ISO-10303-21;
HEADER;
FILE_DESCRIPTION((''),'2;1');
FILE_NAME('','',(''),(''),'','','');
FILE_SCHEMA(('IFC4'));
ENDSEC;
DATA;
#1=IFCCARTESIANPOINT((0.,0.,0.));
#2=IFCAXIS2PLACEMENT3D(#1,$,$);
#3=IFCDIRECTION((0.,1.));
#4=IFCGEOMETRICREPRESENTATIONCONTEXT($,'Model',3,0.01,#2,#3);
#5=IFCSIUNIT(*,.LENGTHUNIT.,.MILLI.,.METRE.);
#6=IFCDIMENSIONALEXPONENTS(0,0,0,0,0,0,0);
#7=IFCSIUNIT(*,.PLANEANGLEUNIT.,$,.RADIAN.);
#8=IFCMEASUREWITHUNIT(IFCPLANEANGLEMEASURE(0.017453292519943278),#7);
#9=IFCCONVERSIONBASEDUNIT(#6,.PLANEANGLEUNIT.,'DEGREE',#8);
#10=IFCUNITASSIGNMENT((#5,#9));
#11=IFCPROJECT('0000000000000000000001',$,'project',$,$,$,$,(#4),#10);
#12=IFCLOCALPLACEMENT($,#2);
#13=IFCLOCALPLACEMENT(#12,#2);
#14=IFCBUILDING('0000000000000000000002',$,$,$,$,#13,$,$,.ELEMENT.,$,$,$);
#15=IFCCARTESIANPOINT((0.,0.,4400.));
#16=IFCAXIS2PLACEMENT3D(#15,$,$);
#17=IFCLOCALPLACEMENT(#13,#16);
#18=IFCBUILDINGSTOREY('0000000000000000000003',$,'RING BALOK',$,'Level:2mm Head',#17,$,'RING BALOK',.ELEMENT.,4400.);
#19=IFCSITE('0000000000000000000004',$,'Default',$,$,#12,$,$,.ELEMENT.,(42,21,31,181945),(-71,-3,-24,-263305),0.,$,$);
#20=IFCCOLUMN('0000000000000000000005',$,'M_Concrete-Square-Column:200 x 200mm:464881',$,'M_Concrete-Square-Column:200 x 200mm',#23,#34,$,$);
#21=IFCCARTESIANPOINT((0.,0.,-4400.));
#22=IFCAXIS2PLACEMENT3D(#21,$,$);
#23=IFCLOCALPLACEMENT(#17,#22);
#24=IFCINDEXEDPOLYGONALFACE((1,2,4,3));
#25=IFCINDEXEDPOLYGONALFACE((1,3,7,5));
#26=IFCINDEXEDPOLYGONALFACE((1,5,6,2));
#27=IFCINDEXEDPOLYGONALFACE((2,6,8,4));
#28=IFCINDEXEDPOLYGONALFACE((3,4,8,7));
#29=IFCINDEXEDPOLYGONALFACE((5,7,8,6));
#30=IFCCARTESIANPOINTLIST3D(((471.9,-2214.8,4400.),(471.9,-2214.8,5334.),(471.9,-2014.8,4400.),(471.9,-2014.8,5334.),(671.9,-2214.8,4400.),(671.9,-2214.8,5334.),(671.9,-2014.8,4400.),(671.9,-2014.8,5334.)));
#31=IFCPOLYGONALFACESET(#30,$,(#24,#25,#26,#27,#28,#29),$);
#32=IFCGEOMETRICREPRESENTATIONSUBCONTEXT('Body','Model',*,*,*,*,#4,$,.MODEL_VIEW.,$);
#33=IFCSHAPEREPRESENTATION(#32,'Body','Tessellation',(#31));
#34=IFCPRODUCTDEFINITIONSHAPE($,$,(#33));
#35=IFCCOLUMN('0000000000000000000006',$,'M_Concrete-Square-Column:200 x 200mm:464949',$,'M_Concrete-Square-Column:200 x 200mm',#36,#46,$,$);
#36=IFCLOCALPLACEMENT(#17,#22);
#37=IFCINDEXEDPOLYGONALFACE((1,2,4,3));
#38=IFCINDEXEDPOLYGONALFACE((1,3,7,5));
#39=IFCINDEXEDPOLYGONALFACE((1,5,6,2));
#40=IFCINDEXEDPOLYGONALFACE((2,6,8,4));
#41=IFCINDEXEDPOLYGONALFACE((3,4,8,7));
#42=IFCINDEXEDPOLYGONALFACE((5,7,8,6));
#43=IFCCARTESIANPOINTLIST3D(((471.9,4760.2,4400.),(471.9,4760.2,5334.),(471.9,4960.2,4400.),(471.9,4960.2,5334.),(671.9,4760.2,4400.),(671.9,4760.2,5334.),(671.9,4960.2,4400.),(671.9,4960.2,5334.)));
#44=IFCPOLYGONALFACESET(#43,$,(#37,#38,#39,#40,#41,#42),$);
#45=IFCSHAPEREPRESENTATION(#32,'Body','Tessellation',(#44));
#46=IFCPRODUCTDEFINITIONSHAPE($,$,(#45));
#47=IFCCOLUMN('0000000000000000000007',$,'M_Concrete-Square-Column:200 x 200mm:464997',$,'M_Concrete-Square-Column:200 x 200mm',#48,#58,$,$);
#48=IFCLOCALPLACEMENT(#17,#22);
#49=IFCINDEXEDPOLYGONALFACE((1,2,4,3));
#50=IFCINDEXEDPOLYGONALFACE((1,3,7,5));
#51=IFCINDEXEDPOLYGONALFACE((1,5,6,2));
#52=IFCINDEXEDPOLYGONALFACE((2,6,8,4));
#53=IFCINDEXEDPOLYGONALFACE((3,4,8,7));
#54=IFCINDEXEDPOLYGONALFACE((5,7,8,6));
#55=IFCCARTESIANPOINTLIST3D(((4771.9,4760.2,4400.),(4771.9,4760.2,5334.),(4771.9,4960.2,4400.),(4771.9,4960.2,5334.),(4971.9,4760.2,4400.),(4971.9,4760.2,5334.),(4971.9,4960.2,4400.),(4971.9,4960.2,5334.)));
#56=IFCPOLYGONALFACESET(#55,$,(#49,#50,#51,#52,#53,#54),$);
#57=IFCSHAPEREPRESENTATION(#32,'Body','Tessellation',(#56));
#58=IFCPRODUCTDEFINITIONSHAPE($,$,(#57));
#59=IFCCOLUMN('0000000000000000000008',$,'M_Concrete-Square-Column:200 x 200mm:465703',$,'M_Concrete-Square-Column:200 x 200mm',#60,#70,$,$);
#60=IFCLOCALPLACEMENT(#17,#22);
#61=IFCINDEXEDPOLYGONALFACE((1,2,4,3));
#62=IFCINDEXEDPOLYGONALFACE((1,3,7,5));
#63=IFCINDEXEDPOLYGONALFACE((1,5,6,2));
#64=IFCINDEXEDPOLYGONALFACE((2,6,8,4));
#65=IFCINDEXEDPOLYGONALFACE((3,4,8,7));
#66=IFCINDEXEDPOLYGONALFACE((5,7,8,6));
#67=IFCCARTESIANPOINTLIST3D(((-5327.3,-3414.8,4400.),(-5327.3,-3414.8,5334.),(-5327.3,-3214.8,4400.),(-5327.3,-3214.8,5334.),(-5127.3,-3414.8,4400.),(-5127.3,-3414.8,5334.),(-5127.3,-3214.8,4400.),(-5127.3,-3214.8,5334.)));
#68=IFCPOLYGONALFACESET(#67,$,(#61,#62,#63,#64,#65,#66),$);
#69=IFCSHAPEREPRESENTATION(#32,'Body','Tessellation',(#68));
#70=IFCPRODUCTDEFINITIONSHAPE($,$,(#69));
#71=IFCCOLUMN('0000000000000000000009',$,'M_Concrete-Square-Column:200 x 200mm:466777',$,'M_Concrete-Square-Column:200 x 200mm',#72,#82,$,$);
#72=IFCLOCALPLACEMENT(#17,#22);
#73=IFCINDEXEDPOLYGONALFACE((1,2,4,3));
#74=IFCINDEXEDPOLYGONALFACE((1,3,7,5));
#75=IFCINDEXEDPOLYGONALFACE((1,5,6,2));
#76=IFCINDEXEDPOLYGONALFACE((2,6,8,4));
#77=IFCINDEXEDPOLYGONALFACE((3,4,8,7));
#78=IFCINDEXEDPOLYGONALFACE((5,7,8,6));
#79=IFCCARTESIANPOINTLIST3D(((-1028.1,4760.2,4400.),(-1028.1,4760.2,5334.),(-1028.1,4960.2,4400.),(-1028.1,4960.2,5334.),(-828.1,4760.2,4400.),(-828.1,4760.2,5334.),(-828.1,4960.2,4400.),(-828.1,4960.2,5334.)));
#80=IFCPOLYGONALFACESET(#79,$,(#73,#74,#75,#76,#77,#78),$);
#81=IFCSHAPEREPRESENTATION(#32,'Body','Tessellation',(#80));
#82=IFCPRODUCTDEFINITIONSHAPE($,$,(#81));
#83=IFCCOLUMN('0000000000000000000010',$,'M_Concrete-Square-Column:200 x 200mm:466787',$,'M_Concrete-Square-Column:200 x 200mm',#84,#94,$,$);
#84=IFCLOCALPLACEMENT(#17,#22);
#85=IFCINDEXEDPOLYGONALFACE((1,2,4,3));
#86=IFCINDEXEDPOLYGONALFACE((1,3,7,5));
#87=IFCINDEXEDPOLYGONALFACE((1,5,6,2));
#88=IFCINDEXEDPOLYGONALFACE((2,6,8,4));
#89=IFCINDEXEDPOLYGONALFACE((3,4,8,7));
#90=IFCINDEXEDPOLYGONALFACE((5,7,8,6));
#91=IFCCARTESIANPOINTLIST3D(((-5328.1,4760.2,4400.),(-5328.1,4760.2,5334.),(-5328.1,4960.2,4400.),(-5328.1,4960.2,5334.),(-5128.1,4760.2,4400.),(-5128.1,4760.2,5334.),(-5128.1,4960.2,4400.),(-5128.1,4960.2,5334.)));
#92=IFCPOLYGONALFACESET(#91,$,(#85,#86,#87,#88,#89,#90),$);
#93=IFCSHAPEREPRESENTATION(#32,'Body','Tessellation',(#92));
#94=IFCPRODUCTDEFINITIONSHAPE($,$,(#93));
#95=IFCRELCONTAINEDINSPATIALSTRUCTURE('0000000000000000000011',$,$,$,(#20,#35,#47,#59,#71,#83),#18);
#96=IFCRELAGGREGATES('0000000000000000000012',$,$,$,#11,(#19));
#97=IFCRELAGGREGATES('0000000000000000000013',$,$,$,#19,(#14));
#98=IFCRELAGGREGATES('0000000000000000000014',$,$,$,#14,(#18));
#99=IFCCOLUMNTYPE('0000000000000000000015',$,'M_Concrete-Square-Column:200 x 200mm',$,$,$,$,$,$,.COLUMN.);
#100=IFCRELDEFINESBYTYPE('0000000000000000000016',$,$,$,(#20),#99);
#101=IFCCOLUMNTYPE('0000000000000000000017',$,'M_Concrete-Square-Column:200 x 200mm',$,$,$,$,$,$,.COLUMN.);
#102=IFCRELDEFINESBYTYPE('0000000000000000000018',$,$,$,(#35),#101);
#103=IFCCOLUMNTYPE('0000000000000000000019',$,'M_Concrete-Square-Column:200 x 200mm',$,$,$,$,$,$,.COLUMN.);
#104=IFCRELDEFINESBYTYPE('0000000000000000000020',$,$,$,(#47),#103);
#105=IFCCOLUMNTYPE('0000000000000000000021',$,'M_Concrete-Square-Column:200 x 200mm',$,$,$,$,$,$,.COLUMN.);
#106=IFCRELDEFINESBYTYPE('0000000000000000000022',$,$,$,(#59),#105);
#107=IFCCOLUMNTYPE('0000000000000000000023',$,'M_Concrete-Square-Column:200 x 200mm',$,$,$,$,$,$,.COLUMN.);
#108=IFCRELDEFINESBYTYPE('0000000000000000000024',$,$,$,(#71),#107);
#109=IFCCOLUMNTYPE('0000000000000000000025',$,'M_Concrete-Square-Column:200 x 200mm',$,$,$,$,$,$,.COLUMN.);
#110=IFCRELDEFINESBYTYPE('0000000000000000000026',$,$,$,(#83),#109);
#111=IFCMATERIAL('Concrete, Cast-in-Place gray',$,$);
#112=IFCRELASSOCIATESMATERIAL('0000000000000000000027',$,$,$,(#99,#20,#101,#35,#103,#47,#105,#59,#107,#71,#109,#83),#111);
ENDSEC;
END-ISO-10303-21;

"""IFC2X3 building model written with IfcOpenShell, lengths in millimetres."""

from ifc_helpers import new_model, entity, si_unit, converted_unit, direction, frame, frame_2d, origin, origin_2d_with_axis, place, context, subcontext, project, spatial, rectangle, extrude, source, transform, mapped, material, type_object, type_shapes, element, save


model = new_model("IFC2X3")

# Units and contexts
model_context = context("Model", 3, precision=0.01, world=origin(), true_north=direction((0.0, 1.0)))
body_context = subcontext(model_context, "Body", "Model", "MODEL_VIEW")
ifc_project = project(units=[si_unit("LENGTHUNIT", "METRE", prefix="MILLI"), converted_unit("PLANEANGLEUNIT", "DEGREE", entity("IfcPlaneAngleMeasure", 0.017453292519943278), si_unit("PLANEANGLEUNIT", "RADIAN"), dimensions=[0, 0, 0, 0, 0, 0, 0])], contexts=[model_context])

# Site, building, storey
site_placement = place(None, origin())
site = spatial("IfcSite", under=ifc_project, at=site_placement, Name="Default", CompositionType="ELEMENT", RefLatitude=(42, 21, 31, 181945), RefLongitude=(-71, -3, -24, -263305), RefElevation=0.0)
building_placement = place(site_placement, origin())
building = spatial("IfcBuilding", under=site, at=building_placement, CompositionType="ELEMENT")
storey_placement = place(building_placement, frame((0.0, 0.0, 4400.0)))
storey = spatial("IfcBuildingStorey", under=building, at=storey_placement, Name="RING BALOK", ObjectType="Level:2mm Head", LongName="RING BALOK", CompositionType="ELEMENT", Elevation=4400.0)

# Columns
ifc_material = material(Name="Concrete, Cast-in-Place gray")
column_type_1 = type_object("IfcColumnType", Name="M_Concrete-Square-Column:200 x 200mm", PredefinedType="COLUMN", material=ifc_material)
shared_shape_1 = source(origin(), body_context, "Body", "SweptSolid", [
    extrude(rectangle(XDim=200.0, YDim=200.0, at=origin_2d_with_axis()), frame((571.9, -2114.8, 4400.0), z_axis=(0.0, 0.0, 1.0), x_axis=(-1.0, 0.0, 0.0)), (0.0, 0.0, 1.0), 934.0),
])
type_shapes(column_type_1, [shared_shape_1])
column_1_placement = place(storey_placement, frame((0.0, 0.0, -4400.0)))
element("IfcColumn", 1, at=column_1_placement, inside=storey, type_object=column_type_1, material=ifc_material, Name="M_Concrete-Square-Column:200 x 200mm:464881", ObjectType="M_Concrete-Square-Column:200 x 200mm", context=body_context, shape_type="MappedRepresentation", body=[
    mapped(shared_shape_1, transform((0.0, 0.0, 0.0), scale=1.0)),
])
column_type_2 = type_object("IfcColumnType", Name="M_Concrete-Square-Column:200 x 200mm", PredefinedType="COLUMN", material=ifc_material)
shared_shape_2 = source(origin(), body_context, "Body", "SweptSolid", [
    extrude(rectangle(XDim=200.0, YDim=200.0, at=origin_2d_with_axis()), frame((571.9, 4860.2, 4400.0), z_axis=(0.0, 0.0, 1.0), x_axis=(-1.0, 0.0, 0.0)), (0.0, 0.0, 1.0), 934.0),
])
type_shapes(column_type_2, [shared_shape_2])
column_2_placement = place(storey_placement, frame((0.0, 0.0, -4400.0)))
element("IfcColumn", 2, at=column_2_placement, inside=storey, type_object=column_type_2, material=ifc_material, Name="M_Concrete-Square-Column:200 x 200mm:464949", ObjectType="M_Concrete-Square-Column:200 x 200mm", context=body_context, shape_type="MappedRepresentation", body=[
    mapped(shared_shape_2, transform((0.0, 0.0, 0.0), scale=1.0)),
])
column_type_3 = type_object("IfcColumnType", Name="M_Concrete-Square-Column:200 x 200mm", PredefinedType="COLUMN", material=ifc_material)
shared_shape_3 = source(origin(), body_context, "Body", "SweptSolid", [
    extrude(rectangle(XDim=200.0, YDim=200.0, at=origin_2d_with_axis()), frame((4871.9, 4860.2, 4400.0), z_axis=(0.0, 0.0, 1.0), x_axis=(-1.0, 0.0, 0.0)), (0.0, 0.0, 1.0), 934.0),
])
type_shapes(column_type_3, [shared_shape_3])
column_3_placement = place(storey_placement, frame((0.0, 0.0, -4400.0)))
element("IfcColumn", 3, at=column_3_placement, inside=storey, type_object=column_type_3, material=ifc_material, Name="M_Concrete-Square-Column:200 x 200mm:464997", ObjectType="M_Concrete-Square-Column:200 x 200mm", context=body_context, shape_type="MappedRepresentation", body=[
    mapped(shared_shape_3, transform((0.0, 0.0, 0.0), scale=1.0)),
])
column_type_4 = type_object("IfcColumnType", Name="M_Concrete-Square-Column:200 x 200mm", PredefinedType="COLUMN", material=ifc_material)
shared_shape_4 = source(origin(), body_context, "Body", "SweptSolid", [
    extrude(rectangle(XDim=200.0, YDim=200.0, at=frame_2d((0.0, 0.0), x_axis=(1.0, 0.0))), frame((-5227.3, -3314.8, 4400.0), z_axis=(0.0, 0.0, 1.0), x_axis=(0.0, -1.0, 0.0)), (0.0, 0.0, 1.0), 934.0),
])
type_shapes(column_type_4, [shared_shape_4])
column_4_placement = place(storey_placement, frame((0.0, 0.0, -4400.0)))
element("IfcColumn", 4, at=column_4_placement, inside=storey, type_object=column_type_4, material=ifc_material, Name="M_Concrete-Square-Column:200 x 200mm:465703", ObjectType="M_Concrete-Square-Column:200 x 200mm", context=body_context, shape_type="MappedRepresentation", body=[
    mapped(shared_shape_4, transform((0.0, 0.0, 0.0), scale=1.0)),
])
column_type_5 = type_object("IfcColumnType", Name="M_Concrete-Square-Column:200 x 200mm", PredefinedType="COLUMN", material=ifc_material)
shared_shape_5 = source(origin(), body_context, "Body", "SweptSolid", [
    extrude(rectangle(XDim=200.0, YDim=200.0, at=origin_2d_with_axis()), frame((-928.1, 4860.2, 4400.0), z_axis=(0.0, 0.0, 1.0), x_axis=(-1.0, 0.0, 0.0)), (0.0, 0.0, 1.0), 934.0),
])
type_shapes(column_type_5, [shared_shape_5])
column_5_placement = place(storey_placement, frame((0.0, 0.0, -4400.0)))
element("IfcColumn", 5, at=column_5_placement, inside=storey, type_object=column_type_5, material=ifc_material, Name="M_Concrete-Square-Column:200 x 200mm:466777", ObjectType="M_Concrete-Square-Column:200 x 200mm", context=body_context, shape_type="MappedRepresentation", body=[
    mapped(shared_shape_5, transform((0.0, 0.0, 0.0), scale=1.0)),
])
column_type_6 = type_object("IfcColumnType", Name="M_Concrete-Square-Column:200 x 200mm", PredefinedType="COLUMN", material=ifc_material)
shared_shape_6 = source(origin(), body_context, "Body", "SweptSolid", [
    extrude(rectangle(XDim=200.0, YDim=200.0, at=origin_2d_with_axis()), frame((-5228.1, 4860.2, 4400.0), z_axis=(0.0, 0.0, 1.0), x_axis=(-1.0, 0.0, 0.0)), (0.0, 0.0, 1.0), 934.0),
])
type_shapes(column_type_6, [shared_shape_6])
column_6_placement = place(storey_placement, frame((0.0, 0.0, -4400.0)))
element("IfcColumn", 6, at=column_6_placement, inside=storey, type_object=column_type_6, material=ifc_material, Name="M_Concrete-Square-Column:200 x 200mm:466787", ObjectType="M_Concrete-Square-Column:200 x 200mm", context=body_context, shape_type="MappedRepresentation", body=[
    mapped(shared_shape_6, transform((0.0, 0.0, 0.0), scale=1.0)),
])

save(model, "model.ifc")
